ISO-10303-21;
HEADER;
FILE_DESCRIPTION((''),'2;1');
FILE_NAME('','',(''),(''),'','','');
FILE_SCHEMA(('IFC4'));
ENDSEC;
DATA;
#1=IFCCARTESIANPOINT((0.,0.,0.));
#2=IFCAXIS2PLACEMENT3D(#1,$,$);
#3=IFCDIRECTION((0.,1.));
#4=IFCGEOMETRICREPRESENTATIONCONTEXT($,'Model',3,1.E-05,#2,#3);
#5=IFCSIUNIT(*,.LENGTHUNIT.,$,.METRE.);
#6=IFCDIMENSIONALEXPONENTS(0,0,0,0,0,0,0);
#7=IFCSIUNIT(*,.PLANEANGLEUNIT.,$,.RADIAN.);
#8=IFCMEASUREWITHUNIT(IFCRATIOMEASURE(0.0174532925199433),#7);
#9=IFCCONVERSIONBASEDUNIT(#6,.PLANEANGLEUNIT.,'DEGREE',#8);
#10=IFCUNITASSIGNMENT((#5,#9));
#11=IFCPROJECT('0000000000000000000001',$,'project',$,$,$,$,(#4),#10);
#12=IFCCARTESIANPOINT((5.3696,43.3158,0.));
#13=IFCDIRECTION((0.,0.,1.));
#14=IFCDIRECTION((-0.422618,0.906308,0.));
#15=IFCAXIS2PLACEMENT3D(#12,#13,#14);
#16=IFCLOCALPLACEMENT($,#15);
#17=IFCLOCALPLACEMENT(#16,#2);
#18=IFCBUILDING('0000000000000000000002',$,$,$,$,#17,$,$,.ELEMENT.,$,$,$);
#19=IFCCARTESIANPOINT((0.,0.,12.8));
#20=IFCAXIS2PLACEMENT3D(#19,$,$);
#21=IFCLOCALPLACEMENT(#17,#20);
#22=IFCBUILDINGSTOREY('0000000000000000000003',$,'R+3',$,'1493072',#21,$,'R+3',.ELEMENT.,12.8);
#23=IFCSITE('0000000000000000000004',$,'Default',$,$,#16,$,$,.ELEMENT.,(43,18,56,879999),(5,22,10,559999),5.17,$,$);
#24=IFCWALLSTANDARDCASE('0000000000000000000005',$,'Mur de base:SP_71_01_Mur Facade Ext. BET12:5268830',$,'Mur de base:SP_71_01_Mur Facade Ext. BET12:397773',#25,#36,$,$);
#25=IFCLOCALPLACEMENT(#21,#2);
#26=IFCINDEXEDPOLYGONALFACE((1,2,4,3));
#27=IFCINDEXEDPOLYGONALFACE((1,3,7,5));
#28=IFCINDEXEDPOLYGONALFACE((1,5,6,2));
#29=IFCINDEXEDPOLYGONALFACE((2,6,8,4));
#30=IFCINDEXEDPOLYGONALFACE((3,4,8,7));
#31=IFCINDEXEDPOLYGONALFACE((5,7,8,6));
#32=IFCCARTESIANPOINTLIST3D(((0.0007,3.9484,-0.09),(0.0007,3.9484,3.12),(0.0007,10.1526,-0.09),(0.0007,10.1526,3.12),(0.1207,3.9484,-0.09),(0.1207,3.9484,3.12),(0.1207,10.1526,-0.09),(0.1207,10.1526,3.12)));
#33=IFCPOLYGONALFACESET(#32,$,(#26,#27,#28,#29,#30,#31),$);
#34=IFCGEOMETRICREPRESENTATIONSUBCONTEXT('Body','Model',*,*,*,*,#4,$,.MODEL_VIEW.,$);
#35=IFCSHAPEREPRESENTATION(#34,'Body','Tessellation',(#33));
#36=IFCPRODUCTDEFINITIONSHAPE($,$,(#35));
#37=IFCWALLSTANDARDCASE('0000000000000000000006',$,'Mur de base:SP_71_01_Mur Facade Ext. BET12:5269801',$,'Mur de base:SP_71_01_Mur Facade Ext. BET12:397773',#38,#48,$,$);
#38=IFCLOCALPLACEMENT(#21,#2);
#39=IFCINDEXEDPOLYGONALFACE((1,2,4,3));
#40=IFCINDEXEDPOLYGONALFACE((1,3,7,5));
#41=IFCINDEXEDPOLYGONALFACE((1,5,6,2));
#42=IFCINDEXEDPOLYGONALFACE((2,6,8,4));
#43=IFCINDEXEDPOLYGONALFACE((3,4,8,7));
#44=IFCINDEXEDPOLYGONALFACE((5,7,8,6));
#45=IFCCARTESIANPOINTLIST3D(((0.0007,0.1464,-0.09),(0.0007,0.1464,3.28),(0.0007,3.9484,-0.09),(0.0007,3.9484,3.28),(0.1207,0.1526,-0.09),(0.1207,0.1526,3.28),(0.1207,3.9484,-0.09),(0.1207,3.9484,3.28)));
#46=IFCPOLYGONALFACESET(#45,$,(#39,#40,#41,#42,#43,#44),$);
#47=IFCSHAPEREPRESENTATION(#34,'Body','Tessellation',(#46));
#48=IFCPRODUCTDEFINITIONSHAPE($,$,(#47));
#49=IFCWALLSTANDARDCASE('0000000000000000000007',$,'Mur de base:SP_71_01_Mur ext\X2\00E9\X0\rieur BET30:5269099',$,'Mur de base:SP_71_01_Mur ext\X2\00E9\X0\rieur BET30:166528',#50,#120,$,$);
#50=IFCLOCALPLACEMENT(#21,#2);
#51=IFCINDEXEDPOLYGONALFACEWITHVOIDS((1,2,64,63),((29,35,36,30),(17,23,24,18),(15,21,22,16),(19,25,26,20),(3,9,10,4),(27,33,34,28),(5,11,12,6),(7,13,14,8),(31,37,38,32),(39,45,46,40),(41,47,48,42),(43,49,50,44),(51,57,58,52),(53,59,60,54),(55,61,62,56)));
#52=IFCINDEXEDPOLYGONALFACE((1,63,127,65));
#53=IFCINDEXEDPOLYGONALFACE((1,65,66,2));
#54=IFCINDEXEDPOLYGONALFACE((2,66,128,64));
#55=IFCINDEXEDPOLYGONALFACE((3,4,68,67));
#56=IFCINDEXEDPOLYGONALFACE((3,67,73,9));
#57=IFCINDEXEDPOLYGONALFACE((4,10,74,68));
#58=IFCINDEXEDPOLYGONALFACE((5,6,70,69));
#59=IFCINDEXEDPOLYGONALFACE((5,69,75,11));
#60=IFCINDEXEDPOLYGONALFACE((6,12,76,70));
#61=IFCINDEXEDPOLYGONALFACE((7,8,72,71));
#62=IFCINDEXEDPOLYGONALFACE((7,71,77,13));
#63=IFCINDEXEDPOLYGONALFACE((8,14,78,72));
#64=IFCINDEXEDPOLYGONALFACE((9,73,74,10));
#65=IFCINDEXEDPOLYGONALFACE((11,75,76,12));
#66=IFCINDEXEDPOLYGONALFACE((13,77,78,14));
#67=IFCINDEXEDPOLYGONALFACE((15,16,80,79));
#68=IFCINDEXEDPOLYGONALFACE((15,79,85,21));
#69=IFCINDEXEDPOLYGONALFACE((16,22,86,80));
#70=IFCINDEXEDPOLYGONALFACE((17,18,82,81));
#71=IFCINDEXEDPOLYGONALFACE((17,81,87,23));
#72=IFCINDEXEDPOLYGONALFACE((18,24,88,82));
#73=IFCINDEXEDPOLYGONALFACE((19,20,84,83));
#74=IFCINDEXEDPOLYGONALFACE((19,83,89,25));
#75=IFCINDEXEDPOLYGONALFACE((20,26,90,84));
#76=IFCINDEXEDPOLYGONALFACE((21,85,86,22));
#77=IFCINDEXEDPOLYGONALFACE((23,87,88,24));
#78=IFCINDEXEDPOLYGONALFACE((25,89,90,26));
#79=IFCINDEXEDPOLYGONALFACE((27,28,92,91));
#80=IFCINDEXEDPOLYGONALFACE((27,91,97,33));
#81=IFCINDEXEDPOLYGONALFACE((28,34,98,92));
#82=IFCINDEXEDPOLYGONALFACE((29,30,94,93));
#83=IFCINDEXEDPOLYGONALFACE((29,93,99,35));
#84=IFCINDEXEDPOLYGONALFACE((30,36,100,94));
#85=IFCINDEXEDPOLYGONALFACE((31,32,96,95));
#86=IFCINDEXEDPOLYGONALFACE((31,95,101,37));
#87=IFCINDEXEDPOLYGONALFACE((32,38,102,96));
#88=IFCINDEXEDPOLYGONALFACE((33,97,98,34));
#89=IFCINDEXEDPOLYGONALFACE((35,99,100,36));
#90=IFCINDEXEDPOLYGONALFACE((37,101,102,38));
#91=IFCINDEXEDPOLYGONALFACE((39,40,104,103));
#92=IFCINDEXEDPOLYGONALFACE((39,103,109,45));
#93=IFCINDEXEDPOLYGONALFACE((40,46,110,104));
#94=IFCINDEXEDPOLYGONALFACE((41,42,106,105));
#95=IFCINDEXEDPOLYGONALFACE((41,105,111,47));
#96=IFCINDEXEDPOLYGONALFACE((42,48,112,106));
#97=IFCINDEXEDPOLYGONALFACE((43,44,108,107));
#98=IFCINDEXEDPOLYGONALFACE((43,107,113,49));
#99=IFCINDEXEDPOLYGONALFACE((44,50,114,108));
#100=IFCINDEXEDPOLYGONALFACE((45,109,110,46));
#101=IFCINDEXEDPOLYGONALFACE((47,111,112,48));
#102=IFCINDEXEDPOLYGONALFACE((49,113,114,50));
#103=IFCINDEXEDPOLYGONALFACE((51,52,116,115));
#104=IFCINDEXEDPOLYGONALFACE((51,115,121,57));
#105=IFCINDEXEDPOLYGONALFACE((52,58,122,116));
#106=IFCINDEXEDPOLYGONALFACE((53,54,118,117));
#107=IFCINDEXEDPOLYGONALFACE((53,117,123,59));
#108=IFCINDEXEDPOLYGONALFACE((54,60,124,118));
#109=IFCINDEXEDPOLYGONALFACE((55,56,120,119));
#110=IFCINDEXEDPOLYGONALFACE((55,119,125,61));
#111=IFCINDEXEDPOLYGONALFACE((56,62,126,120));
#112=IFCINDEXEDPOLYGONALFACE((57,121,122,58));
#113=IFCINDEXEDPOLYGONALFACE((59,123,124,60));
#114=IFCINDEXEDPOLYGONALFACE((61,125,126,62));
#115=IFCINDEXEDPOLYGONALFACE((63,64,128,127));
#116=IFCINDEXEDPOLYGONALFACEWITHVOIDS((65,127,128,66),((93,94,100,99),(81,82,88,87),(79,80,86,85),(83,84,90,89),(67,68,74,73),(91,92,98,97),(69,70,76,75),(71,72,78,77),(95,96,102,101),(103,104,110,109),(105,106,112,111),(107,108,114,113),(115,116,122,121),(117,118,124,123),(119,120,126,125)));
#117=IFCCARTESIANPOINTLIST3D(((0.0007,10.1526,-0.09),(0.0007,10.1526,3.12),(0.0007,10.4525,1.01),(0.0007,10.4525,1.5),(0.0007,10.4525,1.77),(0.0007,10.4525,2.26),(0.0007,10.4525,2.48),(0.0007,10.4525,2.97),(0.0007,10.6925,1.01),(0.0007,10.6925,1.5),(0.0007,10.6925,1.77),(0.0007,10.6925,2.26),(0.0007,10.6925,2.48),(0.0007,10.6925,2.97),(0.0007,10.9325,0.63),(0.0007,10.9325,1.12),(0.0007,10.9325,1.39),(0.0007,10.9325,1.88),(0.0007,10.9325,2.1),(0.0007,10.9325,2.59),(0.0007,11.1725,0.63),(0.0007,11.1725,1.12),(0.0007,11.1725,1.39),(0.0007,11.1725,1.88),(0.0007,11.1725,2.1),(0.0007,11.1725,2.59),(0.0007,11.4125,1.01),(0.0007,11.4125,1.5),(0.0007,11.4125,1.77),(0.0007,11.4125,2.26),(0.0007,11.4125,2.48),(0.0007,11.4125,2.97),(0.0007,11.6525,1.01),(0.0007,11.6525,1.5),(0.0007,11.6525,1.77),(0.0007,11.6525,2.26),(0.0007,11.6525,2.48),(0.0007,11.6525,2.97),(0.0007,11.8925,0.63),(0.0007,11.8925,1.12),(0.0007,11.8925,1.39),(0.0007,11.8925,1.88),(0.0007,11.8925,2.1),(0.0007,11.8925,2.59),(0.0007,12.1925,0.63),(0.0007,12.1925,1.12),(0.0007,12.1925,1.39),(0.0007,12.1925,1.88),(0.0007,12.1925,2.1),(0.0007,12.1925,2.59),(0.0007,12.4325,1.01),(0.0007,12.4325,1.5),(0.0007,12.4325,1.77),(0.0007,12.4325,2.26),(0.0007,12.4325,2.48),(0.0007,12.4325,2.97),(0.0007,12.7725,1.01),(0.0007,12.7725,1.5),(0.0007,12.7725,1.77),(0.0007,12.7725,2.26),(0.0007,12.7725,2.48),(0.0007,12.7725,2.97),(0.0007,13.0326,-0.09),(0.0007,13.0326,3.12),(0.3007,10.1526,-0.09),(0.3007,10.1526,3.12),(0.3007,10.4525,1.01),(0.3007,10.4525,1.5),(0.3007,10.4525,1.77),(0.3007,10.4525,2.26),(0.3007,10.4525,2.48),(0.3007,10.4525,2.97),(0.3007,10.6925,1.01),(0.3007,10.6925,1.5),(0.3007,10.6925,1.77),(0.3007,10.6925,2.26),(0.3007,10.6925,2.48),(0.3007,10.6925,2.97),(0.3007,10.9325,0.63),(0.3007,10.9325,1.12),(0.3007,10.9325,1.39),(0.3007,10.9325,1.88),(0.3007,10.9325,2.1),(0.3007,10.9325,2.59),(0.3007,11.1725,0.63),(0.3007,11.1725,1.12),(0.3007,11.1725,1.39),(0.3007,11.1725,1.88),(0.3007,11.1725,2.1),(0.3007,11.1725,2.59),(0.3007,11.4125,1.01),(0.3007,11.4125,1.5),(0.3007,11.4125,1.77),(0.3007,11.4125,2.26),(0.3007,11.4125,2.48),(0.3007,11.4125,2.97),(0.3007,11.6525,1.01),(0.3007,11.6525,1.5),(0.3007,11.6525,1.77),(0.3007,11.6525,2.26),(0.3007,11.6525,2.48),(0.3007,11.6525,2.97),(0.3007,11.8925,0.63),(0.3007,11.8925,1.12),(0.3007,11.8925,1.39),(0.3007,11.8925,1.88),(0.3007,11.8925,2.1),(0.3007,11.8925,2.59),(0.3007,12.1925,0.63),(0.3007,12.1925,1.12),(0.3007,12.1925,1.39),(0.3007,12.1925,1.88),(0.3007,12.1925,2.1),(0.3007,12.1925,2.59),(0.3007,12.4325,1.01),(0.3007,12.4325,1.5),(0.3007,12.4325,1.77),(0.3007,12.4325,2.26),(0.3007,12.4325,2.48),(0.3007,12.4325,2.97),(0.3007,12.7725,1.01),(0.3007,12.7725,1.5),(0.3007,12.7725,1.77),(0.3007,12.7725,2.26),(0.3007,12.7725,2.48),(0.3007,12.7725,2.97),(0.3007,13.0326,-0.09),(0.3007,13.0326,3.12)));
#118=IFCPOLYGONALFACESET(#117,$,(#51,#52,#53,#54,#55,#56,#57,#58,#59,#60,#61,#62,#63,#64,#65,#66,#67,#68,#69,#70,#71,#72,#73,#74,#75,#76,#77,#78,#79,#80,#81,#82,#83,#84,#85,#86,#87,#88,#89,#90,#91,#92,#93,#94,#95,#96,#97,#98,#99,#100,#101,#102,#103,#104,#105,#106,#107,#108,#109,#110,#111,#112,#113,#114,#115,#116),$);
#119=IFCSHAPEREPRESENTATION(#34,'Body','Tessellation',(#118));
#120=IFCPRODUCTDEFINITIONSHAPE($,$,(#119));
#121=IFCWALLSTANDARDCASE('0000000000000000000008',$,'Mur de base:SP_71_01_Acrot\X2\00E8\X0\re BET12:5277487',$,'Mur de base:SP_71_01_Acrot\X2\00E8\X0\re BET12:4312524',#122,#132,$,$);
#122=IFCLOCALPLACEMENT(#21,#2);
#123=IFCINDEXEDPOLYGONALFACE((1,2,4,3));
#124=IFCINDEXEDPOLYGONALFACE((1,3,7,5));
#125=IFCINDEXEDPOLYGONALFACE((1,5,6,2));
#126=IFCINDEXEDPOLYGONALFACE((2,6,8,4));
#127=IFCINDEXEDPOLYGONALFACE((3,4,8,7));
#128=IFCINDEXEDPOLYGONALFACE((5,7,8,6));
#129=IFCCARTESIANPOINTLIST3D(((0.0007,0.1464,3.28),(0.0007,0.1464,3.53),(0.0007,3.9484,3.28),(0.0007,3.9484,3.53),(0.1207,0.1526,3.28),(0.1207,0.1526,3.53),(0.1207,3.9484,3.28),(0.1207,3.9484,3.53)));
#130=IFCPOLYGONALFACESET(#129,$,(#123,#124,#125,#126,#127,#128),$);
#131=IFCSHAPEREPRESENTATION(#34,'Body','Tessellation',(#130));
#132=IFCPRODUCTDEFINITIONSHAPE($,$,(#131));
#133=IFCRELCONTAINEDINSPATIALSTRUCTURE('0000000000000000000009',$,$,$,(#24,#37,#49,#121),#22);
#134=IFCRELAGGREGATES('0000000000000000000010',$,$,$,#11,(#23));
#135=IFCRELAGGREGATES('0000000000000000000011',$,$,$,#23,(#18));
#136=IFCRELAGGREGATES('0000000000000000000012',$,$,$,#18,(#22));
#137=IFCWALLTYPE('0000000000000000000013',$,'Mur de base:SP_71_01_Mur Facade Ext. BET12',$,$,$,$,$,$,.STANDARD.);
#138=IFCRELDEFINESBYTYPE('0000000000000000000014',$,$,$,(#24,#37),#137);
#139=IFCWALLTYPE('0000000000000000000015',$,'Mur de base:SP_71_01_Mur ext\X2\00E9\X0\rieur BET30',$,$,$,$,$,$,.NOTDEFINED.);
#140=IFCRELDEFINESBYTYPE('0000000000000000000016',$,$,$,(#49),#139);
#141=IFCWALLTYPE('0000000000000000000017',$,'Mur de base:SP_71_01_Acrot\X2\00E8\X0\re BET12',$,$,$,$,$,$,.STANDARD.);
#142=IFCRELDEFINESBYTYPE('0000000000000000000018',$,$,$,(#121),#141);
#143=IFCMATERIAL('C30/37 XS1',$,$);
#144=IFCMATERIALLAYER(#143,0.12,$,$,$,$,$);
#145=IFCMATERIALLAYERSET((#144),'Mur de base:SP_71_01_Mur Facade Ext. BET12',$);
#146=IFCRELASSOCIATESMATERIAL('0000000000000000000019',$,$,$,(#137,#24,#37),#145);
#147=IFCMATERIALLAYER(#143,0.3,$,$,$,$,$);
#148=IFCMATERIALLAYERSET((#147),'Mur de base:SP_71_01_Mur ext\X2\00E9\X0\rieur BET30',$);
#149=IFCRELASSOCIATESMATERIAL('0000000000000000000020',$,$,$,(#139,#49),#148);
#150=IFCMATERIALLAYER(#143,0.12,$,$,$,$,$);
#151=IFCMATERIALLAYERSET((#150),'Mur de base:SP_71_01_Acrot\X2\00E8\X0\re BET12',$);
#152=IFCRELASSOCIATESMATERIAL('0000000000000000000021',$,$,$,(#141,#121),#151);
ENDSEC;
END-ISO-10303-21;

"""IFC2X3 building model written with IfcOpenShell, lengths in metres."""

from ifc_helpers import new_model, entity, si_unit, converted_unit, direction, frame, frame_2d, origin, origin_2d_with_axis, place, context, subcontext, project, spatial, polyline, rectangle, outline, extrude, clip, halfspace, material, layer, layer_set, layer_usage, type_object, element, save


model = new_model("IFC2X3")

# Units and contexts
model_context = context("Model", 3, precision=1e-05, world=origin(), true_north=direction((0.0, 1.0)))
body_context = subcontext(model_context, "Body", "Model", "MODEL_VIEW")
ifc_project = project(units=[si_unit("LENGTHUNIT", "METRE"), converted_unit("PLANEANGLEUNIT", "DEGREE", entity("IfcRatioMeasure", 0.0174532925199433), si_unit("PLANEANGLEUNIT", "RADIAN"), dimensions=[0, 0, 0, 0, 0, 0, 0])], contexts=[model_context])

# Site, building, storey
site_placement = place(None, frame((5.3696, 43.3158, 0.0), z_axis=(0.0, 0.0, 1.0), x_axis=(-0.422618, 0.906308, 0.0)))
site = spatial("IfcSite", under=ifc_project, at=site_placement, Name="Default", CompositionType="ELEMENT", RefLatitude=(43, 18, 56, 879999), RefLongitude=(5, 22, 10, 559999), RefElevation=5.17)
building_placement = place(site_placement, origin())
building = spatial("IfcBuilding", under=site, at=building_placement, CompositionType="ELEMENT")
storey_placement = place(building_placement, frame((0.0, 0.0, 12.8)))
storey = spatial("IfcBuildingStorey", under=building, at=storey_placement, Name="R+3", ObjectType="1493072", LongName="R+3", CompositionType="ELEMENT", Elevation=12.8)

# Shared definitions
ifc_material_1 = material(Name="C30/37 XS1")

# Walls
ifc_layer_1 = layer(ifc_material_1, 0.12)
ifc_layer_set_1 = layer_set([ifc_layer_1], Name="Mur de base:SP_71_01_Mur Facade Ext. BET12")
wall_type_1 = type_object("IfcWallType", Name="Mur de base:SP_71_01_Mur Facade Ext. BET12", PredefinedType="STANDARD", material=ifc_layer_set_1)
ifc_layer_usage_1 = layer_usage(ifc_layer_set_1, "AXIS2", "NEGATIVE", 0.06)
wall_1_placement = place(storey_placement, frame((0.0607, 10.1526, -0.09), z_axis=(0.0, 0.0, 1.0), x_axis=(0.0, -1.0, 0.0)))
element("IfcWallStandardCase", 1, at=wall_1_placement, inside=storey, type_object=wall_type_1, material=ifc_layer_usage_1, Name="Mur de base:SP_71_01_Mur Facade Ext. BET12:5268830", ObjectType="Mur de base:SP_71_01_Mur Facade Ext. BET12:397773", context=body_context, shape_type="SweptSolid", body=[
    extrude(rectangle(XDim=6.2042, YDim=0.12, at=frame_2d((3.1021, 0.0), x_axis=(-1.0, 0.0))), origin(), (0.0, 0.0, 1.0), 3.21),
])
ifc_layer_usage_2 = layer_usage(ifc_layer_set_1, "AXIS2", "NEGATIVE", 0.06)
wall_2_placement = place(storey_placement, frame((0.0607, 3.9484, -0.09), z_axis=(0.0, 0.0, 1.0), x_axis=(0.0, -1.0, 0.0)))
element("IfcWallStandardCase", 2, at=wall_2_placement, inside=storey, type_object=wall_type_1, material=ifc_layer_usage_2, Name="Mur de base:SP_71_01_Mur Facade Ext. BET12:5269801", ObjectType="Mur de base:SP_71_01_Mur Facade Ext. BET12:397773", context=body_context, shape_type="SweptSolid", body=[
    extrude(outline(polyline([(3.802, -0.06), (3.7958, 0.06), (0.0, 0.06), (0.0, -0.06), (3.802, -0.06)])), origin(), (0.0, 0.0, 1.0), 3.37),
])

# Wall, openings
ifc_layer_2 = layer(ifc_material_1, 0.3)
ifc_layer_set_2 = layer_set([ifc_layer_2], Name="Mur de base:SP_71_01_Mur extérieur BET30")
ifc_layer_usage_3 = layer_usage(ifc_layer_set_2, "AXIS2", "NEGATIVE", 0.15)
wall_type_2 = type_object("IfcWallType", Name="Mur de base:SP_71_01_Mur extérieur BET30", PredefinedType="NOTDEFINED", material=ifc_layer_set_2)
wall_3_placement = place(storey_placement, frame((0.1507, 13.0326, -0.09), z_axis=(0.0, 0.0, 1.0), x_axis=(0.0, -1.0, 0.0)))
wall_3 = element("IfcWallStandardCase", 3, at=wall_3_placement, inside=storey, type_object=wall_type_2, material=ifc_layer_usage_3, Name="Mur de base:SP_71_01_Mur extérieur BET30:5269099", ObjectType="Mur de base:SP_71_01_Mur extérieur BET30:166528", context=body_context, shape_type="SweptSolid", body=[
    extrude(rectangle(XDim=2.88, YDim=0.3, at=frame_2d((1.44, 0.0), x_axis=(-1.0, 0.0))), origin(), (0.0, 0.0, 1.0), 3.21),
])
opening_1_placement = place(wall_3_placement, origin())
element("IfcOpeningElement", 4, at=opening_1_placement, cuts=wall_3, ObjectType="Opening", context=body_context, shape_type="SweptSolid", body=[
    extrude(rectangle(XDim=0.49, YDim=0.34, at=frame_2d((0.0, 0.0), x_axis=(1.0, 0.0))), frame((0.4301, 0.15, 1.345), z_axis=(0.0, -1.0, 0.0), x_axis=(0.0, 0.0, 1.0)), (0.0, 0.0, 1.0), 0.3),
])
opening_2_placement = place(wall_3_placement, origin())
element("IfcOpeningElement", 5, at=opening_2_placement, cuts=wall_3, ObjectType="Opening", context=body_context, shape_type="SweptSolid", body=[
    extrude(rectangle(XDim=0.49, YDim=0.34, at=frame_2d((0.0, 0.0), x_axis=(1.0, 0.0))), frame((0.4301, 0.15, 2.105), z_axis=(0.0, -1.0, 0.0), x_axis=(0.0, 0.0, 1.0)), (0.0, 0.0, 1.0), 0.3),
])
opening_3_placement = place(wall_3_placement, origin())
element("IfcOpeningElement", 6, at=opening_3_placement, cuts=wall_3, ObjectType="Opening", context=body_context, shape_type="SweptSolid", body=[
    extrude(rectangle(XDim=0.49, YDim=0.34, at=origin_2d_with_axis()), frame((0.4301, 0.15, 2.815), z_axis=(0.0, -1.0, 0.0), x_axis=(0.0, 0.0, 1.0)), (0.0, 0.0, 1.0), 0.3),
])
opening_4_placement = place(wall_3_placement, origin())
element("IfcOpeningElement", 7, at=opening_4_placement, cuts=wall_3, ObjectType="Opening", context=body_context, shape_type="SweptSolid", body=[
    extrude(rectangle(XDim=0.49, YDim=0.3, at=frame_2d((0.0, 0.0), x_axis=(1.0, 0.0))), frame((0.9901, 0.15, 2.435), z_axis=(0.0, -1.0, 0.0), x_axis=(0.0, 0.0, 1.0)), (0.0, 0.0, 1.0), 0.3),
])
opening_5_placement = place(wall_3_placement, origin())
element("IfcOpeningElement", 8, at=opening_5_placement, cuts=wall_3, ObjectType="Opening", context=body_context, shape_type="SweptSolid", body=[
    extrude(rectangle(XDim=0.49, YDim=0.24, at=origin_2d_with_axis()), frame((1.5001, 0.15, 2.815), z_axis=(0.0, -1.0, 0.0), x_axis=(0.0, 0.0, 1.0)), (0.0, 0.0, 1.0), 0.3),
])
opening_6_placement = place(wall_3_placement, origin())
element("IfcOpeningElement", 9, at=opening_6_placement, cuts=wall_3, ObjectType="Opening", context=body_context, shape_type="SweptSolid", body=[
    extrude(rectangle(XDim=0.49, YDim=0.24, at=frame_2d((0.0, 0.0), x_axis=(1.0, 0.0))), frame((1.9801, 0.15, 2.435), z_axis=(0.0, -1.0, 0.0), x_axis=(0.0, 0.0, 1.0)), (0.0, 0.0, 1.0), 0.3),
])
opening_7_placement = place(wall_3_placement, origin())
element("IfcOpeningElement", 10, at=opening_7_placement, cuts=wall_3, ObjectType="Opening", context=body_context, shape_type="SweptSolid", body=[
    extrude(rectangle(XDim=0.49, YDim=0.24, at=frame_2d((0.0, 0.0), x_axis=(1.0, 0.0))), frame((2.4601, 0.15, 2.815), z_axis=(0.0, -1.0, 0.0), x_axis=(0.0, 0.0, 1.0)), (0.0, 0.0, 1.0), 0.3),
])
opening_8_placement = place(wall_3_placement, origin())
element("IfcOpeningElement", 11, at=opening_8_placement, cuts=wall_3, ObjectType="Opening", context=body_context, shape_type="SweptSolid", body=[
    extrude(rectangle(XDim=0.49, YDim=0.24, at=frame_2d((0.0, 0.0), x_axis=(1.0, 0.0))), frame((2.4601, 0.15, 2.105), z_axis=(0.0, -1.0, 0.0), x_axis=(0.0, 0.0, 1.0)), (0.0, 0.0, 1.0), 0.3),
])
opening_9_placement = place(wall_3_placement, origin())
element("IfcOpeningElement", 12, at=opening_9_placement, cuts=wall_3, ObjectType="Opening", context=body_context, shape_type="SweptSolid", body=[
    extrude(rectangle(XDim=0.49, YDim=0.24, at=frame_2d((0.0, 0.0), x_axis=(1.0, 0.0))), frame((1.5001, 0.15, 2.105), z_axis=(0.0, -1.0, 0.0), x_axis=(0.0, 0.0, 1.0)), (0.0, 0.0, 1.0), 0.3),
])
opening_10_placement = place(wall_3_placement, origin())
element("IfcOpeningElement", 13, at=opening_10_placement, cuts=wall_3, ObjectType="Opening", context=body_context, shape_type="SweptSolid", body=[
    extrude(rectangle(XDim=0.49, YDim=0.3, at=frame_2d((0.0, 0.0), x_axis=(1.0, 0.0))), frame((0.9901, 0.15, 1.725), z_axis=(0.0, -1.0, 0.0), x_axis=(0.0, 0.0, 1.0)), (0.0, 0.0, 1.0), 0.3),
])
opening_11_placement = place(wall_3_placement, origin())
element("IfcOpeningElement", 14, at=opening_11_placement, cuts=wall_3, ObjectType="Opening", context=body_context, shape_type="SweptSolid", body=[
    extrude(rectangle(XDim=0.49, YDim=0.3, at=frame_2d((0.0, 0.0), x_axis=(0.0, 1.0))), frame((0.9901, 0.15, 0.965), z_axis=(0.0, -1.0, 0.0), x_axis=(-1.0, 0.0, 0.0)), (0.0, 0.0, 1.0), 0.3),
])
opening_12_placement = place(wall_3_placement, origin())
element("IfcOpeningElement", 15, at=opening_12_placement, cuts=wall_3, ObjectType="Opening", context=body_context, shape_type="SweptSolid", body=[
    extrude(rectangle(XDim=0.49, YDim=0.24, at=frame_2d((0.0, 0.0), x_axis=(1.0, 0.0))), frame((1.5001, 0.15, 1.345), z_axis=(0.0, -1.0, 0.0), x_axis=(0.0, 0.0, 1.0)), (0.0, 0.0, 1.0), 0.3),
])
opening_13_placement = place(wall_3_placement, origin())
element("IfcOpeningElement", 16, at=opening_13_placement, cuts=wall_3, ObjectType="Opening", context=body_context, shape_type="SweptSolid", body=[
    extrude(rectangle(XDim=0.49, YDim=0.24, at=frame_2d((0.0, 0.0), x_axis=(1.0, 0.0))), frame((1.9801, 0.15, 0.965), z_axis=(0.0, -1.0, 0.0), x_axis=(0.0, 0.0, 1.0)), (0.0, 0.0, 1.0), 0.3),
])
opening_14_placement = place(wall_3_placement, origin())
element("IfcOpeningElement", 17, at=opening_14_placement, cuts=wall_3, ObjectType="Opening", context=body_context, shape_type="SweptSolid", body=[
    extrude(rectangle(XDim=0.49, YDim=0.24, at=frame_2d((0.0, 0.0), x_axis=(1.0, 0.0))), frame((1.9801, 0.15, 1.725), z_axis=(0.0, -1.0, 0.0), x_axis=(0.0, 0.0, 1.0)), (0.0, 0.0, 1.0), 0.3),
])
opening_15_placement = place(wall_3_placement, origin())
element("IfcOpeningElement", 18, at=opening_15_placement, cuts=wall_3, ObjectType="Opening", context=body_context, shape_type="SweptSolid", body=[
    extrude(rectangle(XDim=0.49, YDim=0.24, at=frame_2d((0.0, 0.0), x_axis=(1.0, 0.0))), frame((2.4601, 0.15, 1.345), z_axis=(0.0, -1.0, 0.0), x_axis=(0.0, 0.0, 1.0)), (0.0, 0.0, 1.0), 0.3),
])

# Wall
ifc_layer_3 = layer(ifc_material_1, 0.12)
ifc_layer_set_3 = layer_set([ifc_layer_3], Name="Mur de base:SP_71_01_Acrotère BET12")
ifc_layer_usage_4 = layer_usage(ifc_layer_set_3, "AXIS2", "NEGATIVE", 0.06)
wall_type_3 = type_object("IfcWallType", Name="Mur de base:SP_71_01_Acrotère BET12", PredefinedType="STANDARD", material=ifc_layer_set_3)
wall_4_placement = place(storey_placement, frame((0.0607, 3.9484, 3.28), z_axis=(0.0, 0.0, 1.0), x_axis=(0.0, -1.0, 0.0)))
element("IfcWallStandardCase", 19, at=wall_4_placement, inside=storey, type_object=wall_type_3, material=ifc_layer_usage_4, Name="Mur de base:SP_71_01_Acrotère BET12:5277487", ObjectType="Mur de base:SP_71_01_Acrotère BET12:4312524", context=body_context, shape_type="Clipping", body=[
    clip(extrude(outline(polyline([(3.802, -0.06), (3.7958, 0.06), (0.0, 0.06), (0.0, -0.06), (3.802, -0.06)])), origin(), (0.0, 0.0, 1.0), 0.25), halfspace(origin(), True)),
])

save(model, "model.ifc")
